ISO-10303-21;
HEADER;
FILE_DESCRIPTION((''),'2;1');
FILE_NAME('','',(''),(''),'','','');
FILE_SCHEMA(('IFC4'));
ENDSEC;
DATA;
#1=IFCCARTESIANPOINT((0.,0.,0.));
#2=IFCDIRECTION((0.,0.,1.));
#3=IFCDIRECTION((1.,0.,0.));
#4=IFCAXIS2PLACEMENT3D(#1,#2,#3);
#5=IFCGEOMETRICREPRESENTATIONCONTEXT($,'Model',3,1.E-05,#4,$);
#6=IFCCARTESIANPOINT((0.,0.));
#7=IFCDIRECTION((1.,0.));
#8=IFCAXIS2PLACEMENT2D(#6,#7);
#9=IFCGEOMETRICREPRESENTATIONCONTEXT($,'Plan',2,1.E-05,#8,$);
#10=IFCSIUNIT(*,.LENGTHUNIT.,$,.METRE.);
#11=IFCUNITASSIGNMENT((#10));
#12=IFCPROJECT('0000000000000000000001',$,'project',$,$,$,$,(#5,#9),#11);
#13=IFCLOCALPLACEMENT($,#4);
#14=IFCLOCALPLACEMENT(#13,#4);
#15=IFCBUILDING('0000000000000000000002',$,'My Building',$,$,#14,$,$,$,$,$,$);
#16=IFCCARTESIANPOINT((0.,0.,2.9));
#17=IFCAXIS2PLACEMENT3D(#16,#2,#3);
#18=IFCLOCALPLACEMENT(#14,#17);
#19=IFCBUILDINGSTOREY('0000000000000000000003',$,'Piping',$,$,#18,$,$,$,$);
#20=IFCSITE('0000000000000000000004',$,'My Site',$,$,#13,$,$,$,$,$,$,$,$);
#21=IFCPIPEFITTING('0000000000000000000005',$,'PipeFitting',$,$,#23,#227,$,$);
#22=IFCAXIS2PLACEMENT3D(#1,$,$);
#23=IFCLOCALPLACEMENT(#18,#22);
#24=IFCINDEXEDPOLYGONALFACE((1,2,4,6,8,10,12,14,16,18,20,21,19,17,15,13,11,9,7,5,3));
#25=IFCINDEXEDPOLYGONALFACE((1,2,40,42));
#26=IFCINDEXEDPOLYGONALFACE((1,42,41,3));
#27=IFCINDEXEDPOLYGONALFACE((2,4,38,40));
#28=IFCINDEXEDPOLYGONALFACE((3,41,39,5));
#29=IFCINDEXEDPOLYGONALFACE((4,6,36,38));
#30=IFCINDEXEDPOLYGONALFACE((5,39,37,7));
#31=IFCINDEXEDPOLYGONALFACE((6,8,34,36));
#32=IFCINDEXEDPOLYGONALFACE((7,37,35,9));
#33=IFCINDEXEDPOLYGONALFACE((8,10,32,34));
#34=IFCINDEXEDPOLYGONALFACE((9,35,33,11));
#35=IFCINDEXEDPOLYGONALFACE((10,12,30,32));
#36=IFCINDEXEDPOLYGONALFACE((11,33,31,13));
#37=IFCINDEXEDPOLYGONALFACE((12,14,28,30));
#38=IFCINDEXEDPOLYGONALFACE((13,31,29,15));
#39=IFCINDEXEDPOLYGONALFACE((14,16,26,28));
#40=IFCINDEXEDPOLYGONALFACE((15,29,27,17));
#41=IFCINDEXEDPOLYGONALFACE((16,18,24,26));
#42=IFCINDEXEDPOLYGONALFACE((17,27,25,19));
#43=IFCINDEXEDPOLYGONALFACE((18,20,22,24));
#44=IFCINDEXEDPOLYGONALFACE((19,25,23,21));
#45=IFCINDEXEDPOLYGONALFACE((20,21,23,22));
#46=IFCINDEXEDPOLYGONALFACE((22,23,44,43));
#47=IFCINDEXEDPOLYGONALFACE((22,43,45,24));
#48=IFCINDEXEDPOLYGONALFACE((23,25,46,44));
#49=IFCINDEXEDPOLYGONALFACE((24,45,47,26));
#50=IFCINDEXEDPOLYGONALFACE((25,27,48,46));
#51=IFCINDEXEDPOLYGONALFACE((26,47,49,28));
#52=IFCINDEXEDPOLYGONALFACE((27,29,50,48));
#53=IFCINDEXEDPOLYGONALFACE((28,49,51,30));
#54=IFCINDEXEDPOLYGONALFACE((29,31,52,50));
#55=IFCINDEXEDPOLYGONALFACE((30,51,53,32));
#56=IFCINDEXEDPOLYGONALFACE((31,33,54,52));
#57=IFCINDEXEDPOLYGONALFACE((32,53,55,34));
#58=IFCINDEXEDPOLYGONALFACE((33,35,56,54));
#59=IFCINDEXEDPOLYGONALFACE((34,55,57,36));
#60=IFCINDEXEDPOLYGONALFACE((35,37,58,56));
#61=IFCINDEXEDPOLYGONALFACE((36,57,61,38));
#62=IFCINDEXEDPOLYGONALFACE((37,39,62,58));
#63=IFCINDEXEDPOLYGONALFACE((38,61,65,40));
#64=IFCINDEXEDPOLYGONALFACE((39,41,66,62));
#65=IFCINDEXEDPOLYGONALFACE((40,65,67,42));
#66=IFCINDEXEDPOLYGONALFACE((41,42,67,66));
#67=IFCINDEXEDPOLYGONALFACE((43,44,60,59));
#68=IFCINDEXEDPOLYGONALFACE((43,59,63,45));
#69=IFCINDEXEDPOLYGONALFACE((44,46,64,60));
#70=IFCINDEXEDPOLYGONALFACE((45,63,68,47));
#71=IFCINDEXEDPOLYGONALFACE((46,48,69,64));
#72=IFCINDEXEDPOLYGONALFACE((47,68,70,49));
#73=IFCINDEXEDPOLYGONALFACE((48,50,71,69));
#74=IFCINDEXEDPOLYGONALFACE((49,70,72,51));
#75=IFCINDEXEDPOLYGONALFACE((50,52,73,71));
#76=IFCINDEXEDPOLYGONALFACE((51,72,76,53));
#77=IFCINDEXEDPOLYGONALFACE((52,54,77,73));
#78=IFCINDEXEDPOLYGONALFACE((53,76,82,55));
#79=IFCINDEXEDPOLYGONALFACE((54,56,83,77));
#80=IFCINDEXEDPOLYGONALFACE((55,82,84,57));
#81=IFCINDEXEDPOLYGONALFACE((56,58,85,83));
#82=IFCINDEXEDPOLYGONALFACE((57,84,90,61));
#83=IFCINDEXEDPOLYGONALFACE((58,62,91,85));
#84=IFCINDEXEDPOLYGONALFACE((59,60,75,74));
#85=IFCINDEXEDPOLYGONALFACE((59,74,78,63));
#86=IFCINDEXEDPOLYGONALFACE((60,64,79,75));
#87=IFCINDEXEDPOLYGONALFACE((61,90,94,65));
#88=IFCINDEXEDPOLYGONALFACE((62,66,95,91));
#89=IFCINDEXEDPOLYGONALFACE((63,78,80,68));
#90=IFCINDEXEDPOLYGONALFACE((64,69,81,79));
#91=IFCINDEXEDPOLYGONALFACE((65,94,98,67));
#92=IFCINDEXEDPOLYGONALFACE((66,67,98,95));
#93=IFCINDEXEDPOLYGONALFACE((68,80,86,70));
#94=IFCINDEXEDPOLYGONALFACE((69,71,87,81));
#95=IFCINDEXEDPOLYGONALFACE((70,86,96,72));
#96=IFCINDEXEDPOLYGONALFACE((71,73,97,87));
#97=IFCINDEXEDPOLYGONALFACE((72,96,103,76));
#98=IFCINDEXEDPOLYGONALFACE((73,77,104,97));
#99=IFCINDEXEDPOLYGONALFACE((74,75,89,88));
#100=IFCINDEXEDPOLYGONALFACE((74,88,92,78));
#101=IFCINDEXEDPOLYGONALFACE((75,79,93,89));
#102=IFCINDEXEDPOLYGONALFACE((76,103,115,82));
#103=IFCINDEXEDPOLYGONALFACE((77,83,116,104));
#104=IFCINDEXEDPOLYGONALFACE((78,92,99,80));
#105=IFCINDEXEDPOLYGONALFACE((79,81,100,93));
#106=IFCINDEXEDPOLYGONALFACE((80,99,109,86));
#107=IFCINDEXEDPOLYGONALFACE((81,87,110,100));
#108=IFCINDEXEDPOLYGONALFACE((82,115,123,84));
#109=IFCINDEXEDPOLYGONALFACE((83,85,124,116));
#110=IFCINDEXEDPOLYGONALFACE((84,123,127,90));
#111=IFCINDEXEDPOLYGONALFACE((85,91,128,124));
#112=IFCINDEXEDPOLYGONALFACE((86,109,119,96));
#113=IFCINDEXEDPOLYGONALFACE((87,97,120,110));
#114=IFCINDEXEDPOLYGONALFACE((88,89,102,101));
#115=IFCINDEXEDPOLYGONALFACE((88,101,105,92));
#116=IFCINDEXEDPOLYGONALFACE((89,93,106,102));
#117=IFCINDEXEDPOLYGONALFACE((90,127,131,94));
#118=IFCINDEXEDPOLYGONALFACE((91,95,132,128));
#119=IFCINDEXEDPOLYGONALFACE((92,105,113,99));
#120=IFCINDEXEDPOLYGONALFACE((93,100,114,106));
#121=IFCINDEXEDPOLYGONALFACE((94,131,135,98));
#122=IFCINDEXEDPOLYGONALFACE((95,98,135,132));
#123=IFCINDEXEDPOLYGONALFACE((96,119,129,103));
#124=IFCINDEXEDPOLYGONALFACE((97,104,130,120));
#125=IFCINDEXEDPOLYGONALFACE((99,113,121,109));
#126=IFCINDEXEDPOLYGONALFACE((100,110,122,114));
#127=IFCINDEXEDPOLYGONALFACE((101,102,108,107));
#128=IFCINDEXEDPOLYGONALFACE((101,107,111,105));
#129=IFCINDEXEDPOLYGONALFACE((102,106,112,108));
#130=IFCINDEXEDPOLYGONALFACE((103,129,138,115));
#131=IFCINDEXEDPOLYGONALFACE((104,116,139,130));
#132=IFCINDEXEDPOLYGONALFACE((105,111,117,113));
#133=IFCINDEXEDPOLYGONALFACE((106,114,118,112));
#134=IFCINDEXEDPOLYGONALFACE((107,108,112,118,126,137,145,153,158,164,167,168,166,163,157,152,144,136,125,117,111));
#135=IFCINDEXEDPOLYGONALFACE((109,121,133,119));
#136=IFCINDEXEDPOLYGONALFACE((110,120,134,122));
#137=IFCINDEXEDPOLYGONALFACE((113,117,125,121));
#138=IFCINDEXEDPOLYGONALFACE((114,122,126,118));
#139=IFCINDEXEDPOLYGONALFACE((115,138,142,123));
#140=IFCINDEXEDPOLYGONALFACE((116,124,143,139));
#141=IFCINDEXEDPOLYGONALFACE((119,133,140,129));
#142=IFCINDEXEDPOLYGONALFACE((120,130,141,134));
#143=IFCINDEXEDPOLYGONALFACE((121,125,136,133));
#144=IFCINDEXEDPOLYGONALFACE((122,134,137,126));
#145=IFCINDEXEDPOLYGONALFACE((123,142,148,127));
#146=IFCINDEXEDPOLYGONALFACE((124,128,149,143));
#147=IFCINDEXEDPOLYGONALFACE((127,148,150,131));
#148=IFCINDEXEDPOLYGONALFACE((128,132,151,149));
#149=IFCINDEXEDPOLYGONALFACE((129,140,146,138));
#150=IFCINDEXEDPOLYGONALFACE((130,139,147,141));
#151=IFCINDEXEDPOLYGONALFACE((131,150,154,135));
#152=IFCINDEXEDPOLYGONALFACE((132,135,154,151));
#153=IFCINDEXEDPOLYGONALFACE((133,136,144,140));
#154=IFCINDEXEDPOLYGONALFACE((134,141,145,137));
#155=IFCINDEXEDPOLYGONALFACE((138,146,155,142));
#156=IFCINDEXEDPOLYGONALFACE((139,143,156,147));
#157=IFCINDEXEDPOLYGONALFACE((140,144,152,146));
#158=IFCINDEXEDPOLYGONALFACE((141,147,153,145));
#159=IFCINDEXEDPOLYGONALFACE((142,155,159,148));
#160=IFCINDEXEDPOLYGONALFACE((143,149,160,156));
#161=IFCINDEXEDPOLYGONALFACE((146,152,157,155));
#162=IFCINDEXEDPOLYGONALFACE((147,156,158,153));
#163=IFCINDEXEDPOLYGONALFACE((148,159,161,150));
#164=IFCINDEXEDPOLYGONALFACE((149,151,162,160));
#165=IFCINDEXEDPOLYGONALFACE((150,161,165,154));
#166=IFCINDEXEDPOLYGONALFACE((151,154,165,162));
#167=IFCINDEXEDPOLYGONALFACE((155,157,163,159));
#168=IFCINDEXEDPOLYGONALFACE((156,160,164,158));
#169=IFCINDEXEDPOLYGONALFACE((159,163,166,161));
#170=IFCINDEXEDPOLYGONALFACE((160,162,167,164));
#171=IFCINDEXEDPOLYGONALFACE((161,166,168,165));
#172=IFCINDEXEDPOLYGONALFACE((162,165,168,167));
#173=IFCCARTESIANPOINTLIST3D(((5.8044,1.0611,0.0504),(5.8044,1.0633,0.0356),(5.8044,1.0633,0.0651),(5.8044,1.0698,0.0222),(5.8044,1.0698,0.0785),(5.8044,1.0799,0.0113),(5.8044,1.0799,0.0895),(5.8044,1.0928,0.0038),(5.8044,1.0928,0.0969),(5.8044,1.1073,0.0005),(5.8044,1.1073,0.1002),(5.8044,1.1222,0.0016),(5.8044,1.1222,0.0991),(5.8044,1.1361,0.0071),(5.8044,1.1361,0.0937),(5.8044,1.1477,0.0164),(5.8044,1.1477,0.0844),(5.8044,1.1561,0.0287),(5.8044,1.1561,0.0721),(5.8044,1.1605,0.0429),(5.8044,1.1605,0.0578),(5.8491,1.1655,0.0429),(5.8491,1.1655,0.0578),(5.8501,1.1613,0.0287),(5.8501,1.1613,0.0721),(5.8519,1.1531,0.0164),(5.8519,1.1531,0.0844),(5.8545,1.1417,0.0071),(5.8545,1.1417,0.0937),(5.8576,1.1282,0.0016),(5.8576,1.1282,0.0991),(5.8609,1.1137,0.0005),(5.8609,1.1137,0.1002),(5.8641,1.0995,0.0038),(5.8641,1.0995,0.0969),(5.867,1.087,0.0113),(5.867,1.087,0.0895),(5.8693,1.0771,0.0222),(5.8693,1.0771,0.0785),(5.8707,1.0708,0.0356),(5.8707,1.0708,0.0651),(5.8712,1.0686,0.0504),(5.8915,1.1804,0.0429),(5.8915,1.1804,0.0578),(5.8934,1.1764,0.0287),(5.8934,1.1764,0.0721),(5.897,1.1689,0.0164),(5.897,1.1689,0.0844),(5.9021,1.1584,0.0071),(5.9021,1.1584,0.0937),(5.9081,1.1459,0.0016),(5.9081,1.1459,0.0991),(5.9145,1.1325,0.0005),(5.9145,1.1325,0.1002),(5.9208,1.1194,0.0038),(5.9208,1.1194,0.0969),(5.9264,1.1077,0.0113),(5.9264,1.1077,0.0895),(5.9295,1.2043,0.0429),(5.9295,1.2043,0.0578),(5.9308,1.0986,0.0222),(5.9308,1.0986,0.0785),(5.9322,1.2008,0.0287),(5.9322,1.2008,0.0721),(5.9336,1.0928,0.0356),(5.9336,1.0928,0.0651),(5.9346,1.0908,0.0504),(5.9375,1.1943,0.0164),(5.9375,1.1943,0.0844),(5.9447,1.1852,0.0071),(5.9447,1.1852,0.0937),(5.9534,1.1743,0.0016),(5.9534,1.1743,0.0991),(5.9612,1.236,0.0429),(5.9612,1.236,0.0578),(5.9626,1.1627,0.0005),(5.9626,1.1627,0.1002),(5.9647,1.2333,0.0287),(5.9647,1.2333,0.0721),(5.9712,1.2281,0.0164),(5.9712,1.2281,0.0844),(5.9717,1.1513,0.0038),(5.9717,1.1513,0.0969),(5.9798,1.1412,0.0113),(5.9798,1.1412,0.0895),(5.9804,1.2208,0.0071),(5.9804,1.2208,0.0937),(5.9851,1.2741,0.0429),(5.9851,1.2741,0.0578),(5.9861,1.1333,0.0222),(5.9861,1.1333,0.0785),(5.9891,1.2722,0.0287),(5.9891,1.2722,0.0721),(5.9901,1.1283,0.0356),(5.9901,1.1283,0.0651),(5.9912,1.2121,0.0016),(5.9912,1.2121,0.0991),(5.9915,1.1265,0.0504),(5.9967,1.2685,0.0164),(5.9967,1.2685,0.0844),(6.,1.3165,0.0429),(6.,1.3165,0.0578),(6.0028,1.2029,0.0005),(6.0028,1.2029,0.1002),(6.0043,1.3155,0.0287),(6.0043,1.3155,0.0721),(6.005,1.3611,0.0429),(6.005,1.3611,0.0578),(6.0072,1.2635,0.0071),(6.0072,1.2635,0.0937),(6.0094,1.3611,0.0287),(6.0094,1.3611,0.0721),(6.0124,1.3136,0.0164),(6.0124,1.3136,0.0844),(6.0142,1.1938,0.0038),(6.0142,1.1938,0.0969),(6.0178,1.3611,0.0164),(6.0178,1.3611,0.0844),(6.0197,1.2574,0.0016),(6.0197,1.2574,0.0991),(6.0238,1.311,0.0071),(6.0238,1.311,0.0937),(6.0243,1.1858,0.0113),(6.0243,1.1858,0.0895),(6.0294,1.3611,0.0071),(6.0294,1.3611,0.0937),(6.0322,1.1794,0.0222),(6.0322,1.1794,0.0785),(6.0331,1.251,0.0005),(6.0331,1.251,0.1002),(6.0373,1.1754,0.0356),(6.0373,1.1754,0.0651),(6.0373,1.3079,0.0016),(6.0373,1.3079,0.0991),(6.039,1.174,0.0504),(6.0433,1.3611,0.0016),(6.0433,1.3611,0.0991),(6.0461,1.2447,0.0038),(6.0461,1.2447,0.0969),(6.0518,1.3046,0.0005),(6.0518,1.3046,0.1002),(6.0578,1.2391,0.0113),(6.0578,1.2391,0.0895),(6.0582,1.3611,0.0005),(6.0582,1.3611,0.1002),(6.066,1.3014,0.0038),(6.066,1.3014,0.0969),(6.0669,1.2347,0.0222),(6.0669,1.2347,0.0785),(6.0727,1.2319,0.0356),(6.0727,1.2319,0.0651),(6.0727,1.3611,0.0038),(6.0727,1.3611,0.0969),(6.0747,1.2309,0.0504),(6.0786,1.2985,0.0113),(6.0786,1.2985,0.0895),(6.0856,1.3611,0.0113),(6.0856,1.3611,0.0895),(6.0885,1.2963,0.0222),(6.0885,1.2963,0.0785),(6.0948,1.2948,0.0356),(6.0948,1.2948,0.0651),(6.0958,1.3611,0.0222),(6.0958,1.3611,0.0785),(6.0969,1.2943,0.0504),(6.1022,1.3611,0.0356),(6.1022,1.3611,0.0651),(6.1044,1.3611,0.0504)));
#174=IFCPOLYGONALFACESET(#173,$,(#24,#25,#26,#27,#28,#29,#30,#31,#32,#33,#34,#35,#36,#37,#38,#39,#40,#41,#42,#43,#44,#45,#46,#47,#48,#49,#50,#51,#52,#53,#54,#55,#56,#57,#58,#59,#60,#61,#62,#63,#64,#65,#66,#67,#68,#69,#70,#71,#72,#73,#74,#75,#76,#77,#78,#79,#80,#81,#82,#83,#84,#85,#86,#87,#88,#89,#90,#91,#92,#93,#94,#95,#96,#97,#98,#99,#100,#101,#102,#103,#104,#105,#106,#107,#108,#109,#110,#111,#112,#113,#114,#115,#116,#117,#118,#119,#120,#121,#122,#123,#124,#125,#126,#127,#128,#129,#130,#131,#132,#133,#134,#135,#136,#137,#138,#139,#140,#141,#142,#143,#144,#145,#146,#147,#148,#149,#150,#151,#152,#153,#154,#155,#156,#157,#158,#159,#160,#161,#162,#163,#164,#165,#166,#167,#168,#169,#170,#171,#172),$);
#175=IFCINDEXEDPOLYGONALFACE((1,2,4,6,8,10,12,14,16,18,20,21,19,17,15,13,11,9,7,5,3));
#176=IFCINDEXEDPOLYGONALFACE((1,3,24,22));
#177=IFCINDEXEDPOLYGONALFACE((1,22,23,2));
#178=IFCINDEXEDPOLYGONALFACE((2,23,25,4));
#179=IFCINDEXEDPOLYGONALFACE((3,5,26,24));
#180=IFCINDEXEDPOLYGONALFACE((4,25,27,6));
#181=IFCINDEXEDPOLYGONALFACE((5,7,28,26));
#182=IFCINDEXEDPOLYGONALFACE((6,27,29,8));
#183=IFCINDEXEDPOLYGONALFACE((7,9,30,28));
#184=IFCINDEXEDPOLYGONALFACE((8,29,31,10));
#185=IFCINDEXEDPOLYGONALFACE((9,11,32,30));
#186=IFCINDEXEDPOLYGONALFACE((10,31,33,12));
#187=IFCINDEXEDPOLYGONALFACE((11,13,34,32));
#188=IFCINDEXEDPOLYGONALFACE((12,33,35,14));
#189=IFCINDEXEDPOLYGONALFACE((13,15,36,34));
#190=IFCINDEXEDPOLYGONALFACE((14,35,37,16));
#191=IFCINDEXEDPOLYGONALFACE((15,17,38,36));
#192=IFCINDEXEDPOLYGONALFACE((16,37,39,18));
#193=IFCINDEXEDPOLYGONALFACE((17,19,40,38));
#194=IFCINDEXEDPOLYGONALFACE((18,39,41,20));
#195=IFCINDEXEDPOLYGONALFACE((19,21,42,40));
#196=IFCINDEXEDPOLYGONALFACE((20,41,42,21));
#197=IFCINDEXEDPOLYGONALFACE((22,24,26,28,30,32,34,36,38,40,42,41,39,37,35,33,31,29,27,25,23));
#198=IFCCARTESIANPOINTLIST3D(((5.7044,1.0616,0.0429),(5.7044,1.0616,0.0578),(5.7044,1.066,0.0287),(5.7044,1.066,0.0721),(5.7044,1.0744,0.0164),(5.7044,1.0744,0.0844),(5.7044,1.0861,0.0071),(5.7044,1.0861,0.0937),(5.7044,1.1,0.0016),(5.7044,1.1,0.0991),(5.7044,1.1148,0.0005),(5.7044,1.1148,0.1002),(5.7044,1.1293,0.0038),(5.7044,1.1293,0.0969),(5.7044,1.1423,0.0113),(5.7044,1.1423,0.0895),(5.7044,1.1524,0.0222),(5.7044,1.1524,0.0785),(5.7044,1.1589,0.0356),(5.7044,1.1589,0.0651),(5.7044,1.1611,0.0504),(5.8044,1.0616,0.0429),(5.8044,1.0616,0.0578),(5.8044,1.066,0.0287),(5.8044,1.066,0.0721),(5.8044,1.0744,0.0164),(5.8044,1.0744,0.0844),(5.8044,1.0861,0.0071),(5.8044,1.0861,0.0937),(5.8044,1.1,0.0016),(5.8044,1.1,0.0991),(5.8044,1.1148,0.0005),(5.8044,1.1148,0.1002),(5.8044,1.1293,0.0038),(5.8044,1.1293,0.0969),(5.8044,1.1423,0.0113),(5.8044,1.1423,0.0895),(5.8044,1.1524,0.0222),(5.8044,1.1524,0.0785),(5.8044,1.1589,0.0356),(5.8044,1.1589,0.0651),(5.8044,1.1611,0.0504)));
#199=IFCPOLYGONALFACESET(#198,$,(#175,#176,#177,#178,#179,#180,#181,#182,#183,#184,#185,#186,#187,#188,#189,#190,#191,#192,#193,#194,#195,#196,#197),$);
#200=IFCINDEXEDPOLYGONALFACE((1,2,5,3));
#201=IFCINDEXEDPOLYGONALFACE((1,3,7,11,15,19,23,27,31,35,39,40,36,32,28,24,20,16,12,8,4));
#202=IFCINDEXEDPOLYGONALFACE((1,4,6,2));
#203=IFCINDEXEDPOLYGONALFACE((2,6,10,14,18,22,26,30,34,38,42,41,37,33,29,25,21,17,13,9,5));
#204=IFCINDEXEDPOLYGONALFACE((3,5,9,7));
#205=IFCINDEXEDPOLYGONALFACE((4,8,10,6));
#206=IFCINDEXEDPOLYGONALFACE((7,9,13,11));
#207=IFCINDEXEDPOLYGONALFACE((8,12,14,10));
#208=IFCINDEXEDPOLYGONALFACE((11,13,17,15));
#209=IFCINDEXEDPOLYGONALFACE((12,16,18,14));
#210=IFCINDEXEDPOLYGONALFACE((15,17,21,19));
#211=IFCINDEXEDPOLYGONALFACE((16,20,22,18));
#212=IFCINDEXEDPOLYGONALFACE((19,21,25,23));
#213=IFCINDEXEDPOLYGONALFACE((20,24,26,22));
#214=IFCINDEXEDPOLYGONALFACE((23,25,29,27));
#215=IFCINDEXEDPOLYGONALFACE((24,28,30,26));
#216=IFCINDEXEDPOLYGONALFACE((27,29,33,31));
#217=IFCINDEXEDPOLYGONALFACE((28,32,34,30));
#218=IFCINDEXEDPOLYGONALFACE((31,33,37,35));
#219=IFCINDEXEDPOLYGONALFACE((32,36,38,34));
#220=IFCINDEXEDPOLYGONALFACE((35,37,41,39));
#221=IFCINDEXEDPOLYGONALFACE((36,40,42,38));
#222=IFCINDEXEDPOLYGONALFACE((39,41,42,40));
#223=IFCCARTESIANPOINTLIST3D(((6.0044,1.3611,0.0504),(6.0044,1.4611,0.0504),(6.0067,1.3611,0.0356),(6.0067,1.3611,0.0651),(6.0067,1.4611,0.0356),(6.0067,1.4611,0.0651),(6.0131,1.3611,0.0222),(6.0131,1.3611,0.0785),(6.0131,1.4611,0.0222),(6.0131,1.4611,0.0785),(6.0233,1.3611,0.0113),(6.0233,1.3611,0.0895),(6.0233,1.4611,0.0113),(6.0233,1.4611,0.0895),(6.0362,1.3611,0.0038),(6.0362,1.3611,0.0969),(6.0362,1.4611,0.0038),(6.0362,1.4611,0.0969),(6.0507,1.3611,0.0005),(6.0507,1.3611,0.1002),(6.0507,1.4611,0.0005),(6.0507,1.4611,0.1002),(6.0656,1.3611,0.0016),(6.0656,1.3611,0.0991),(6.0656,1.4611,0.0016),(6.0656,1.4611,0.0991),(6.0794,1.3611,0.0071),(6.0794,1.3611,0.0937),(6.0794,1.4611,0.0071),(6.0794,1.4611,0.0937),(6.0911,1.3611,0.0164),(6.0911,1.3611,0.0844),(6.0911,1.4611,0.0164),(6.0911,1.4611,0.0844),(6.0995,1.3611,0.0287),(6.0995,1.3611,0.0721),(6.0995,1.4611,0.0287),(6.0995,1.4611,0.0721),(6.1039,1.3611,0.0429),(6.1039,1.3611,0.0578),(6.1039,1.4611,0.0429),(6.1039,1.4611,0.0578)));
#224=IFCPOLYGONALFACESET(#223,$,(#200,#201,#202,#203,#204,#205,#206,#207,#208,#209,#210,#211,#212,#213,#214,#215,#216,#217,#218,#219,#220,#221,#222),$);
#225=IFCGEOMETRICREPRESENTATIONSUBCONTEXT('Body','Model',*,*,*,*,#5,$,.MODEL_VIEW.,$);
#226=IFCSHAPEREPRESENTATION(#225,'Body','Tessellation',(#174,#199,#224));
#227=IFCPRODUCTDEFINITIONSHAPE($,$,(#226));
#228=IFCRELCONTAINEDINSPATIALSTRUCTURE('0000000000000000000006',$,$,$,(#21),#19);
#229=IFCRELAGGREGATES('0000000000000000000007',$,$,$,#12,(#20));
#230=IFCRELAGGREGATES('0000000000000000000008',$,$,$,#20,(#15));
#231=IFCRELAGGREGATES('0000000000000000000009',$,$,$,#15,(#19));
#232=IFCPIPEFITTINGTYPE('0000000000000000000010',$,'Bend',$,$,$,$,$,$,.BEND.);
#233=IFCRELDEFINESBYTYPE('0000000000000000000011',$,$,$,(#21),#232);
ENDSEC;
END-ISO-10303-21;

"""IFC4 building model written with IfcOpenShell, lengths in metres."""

from ifc_helpers import new_model, entity, si_unit, frame, origin_with_axes, origin_2d_with_axis, place, context, subcontext, project, spatial, circle, extrude, source, transform, mapped, type_object, type_shapes, element, save


model = new_model("IFC4")

# Units and contexts
model_context = context("Model", 3, precision=1e-05, world=origin_with_axes())
plan_context = context("Plan", 2, precision=1e-05, world=origin_2d_with_axis())
body_context = subcontext(model_context, "Body", "Model", "MODEL_VIEW")
ifc_project = project(units=[si_unit("LENGTHUNIT", "METRE")], contexts=[model_context, plan_context])

# Site, building, storey
site_placement = place(None, origin_with_axes())
site = spatial("IfcSite", under=ifc_project, at=site_placement, Name="My Site")
building_placement = place(site_placement, origin_with_axes())
building = spatial("IfcBuilding", under=site, at=building_placement, Name="My Building")
storey_placement = place(building_placement, frame((0.0, 0.0, 2.9), z_axis=(0.0, 0.0, 1.0), x_axis=(1.0, 0.0, 0.0)))
storey = spatial("IfcBuildingStorey", under=building, at=storey_placement, Name="Piping")

# Pipe fitting
pipe_fitting_type_1 = type_object("IfcPipeFittingType", Name="Bend", PredefinedType="BEND")
shared_shape = source(origin_with_axes(), body_context, "Body", "SolidModel", [
    entity("IfcSweptDiskSolid", entity("IfcIndexedPolyCurve", entity("IfcCartesianPointList3D", [[0.0, 0.0, -0.1], [0.0732, 0.0, -0.2768], [0.25, 0.0, -0.35]]), [entity("IfcArcIndex", [1, 2, 3])]), 0.05),
    extrude(circle(Radius=0.05), origin_with_axes(), (0.0, 0.0, -1.0), 0.1),
    extrude(circle(Radius=0.05), frame((0.25, 0.0, -0.35), z_axis=(1.0, 0.0, 0.0), x_axis=(0.0, 0.0, 1.0)), (0.0, 0.0, 1.0), 0.1),
])
type_shapes(pipe_fitting_type_1, [shared_shape])
for number, where, z_axis, x_axis, name in (
    (1, (5.7044, 1.1111, 0.0504), (-1.0, 0.000001, -0.000001), (0.000001, 1.0, 0.0), "PipeFitting"),
):
    element("IfcPipeFitting", number, at=place(storey_placement, frame(where, z_axis=z_axis, x_axis=x_axis)), inside=storey, type_object=pipe_fitting_type_1, Name=name, context=body_context, shape_type="MappedRepresentation", body=[
        mapped(shared_shape, transform((0.0, 0.0, 0.0), x_axis=(1.0, 0.0, 0.0), y_axis=(0.0, 1.0, 0.0), z_axis=(0.0, 0.0, 1.0), scale=1.0)),
    ])

save(model, "model.ifc")
